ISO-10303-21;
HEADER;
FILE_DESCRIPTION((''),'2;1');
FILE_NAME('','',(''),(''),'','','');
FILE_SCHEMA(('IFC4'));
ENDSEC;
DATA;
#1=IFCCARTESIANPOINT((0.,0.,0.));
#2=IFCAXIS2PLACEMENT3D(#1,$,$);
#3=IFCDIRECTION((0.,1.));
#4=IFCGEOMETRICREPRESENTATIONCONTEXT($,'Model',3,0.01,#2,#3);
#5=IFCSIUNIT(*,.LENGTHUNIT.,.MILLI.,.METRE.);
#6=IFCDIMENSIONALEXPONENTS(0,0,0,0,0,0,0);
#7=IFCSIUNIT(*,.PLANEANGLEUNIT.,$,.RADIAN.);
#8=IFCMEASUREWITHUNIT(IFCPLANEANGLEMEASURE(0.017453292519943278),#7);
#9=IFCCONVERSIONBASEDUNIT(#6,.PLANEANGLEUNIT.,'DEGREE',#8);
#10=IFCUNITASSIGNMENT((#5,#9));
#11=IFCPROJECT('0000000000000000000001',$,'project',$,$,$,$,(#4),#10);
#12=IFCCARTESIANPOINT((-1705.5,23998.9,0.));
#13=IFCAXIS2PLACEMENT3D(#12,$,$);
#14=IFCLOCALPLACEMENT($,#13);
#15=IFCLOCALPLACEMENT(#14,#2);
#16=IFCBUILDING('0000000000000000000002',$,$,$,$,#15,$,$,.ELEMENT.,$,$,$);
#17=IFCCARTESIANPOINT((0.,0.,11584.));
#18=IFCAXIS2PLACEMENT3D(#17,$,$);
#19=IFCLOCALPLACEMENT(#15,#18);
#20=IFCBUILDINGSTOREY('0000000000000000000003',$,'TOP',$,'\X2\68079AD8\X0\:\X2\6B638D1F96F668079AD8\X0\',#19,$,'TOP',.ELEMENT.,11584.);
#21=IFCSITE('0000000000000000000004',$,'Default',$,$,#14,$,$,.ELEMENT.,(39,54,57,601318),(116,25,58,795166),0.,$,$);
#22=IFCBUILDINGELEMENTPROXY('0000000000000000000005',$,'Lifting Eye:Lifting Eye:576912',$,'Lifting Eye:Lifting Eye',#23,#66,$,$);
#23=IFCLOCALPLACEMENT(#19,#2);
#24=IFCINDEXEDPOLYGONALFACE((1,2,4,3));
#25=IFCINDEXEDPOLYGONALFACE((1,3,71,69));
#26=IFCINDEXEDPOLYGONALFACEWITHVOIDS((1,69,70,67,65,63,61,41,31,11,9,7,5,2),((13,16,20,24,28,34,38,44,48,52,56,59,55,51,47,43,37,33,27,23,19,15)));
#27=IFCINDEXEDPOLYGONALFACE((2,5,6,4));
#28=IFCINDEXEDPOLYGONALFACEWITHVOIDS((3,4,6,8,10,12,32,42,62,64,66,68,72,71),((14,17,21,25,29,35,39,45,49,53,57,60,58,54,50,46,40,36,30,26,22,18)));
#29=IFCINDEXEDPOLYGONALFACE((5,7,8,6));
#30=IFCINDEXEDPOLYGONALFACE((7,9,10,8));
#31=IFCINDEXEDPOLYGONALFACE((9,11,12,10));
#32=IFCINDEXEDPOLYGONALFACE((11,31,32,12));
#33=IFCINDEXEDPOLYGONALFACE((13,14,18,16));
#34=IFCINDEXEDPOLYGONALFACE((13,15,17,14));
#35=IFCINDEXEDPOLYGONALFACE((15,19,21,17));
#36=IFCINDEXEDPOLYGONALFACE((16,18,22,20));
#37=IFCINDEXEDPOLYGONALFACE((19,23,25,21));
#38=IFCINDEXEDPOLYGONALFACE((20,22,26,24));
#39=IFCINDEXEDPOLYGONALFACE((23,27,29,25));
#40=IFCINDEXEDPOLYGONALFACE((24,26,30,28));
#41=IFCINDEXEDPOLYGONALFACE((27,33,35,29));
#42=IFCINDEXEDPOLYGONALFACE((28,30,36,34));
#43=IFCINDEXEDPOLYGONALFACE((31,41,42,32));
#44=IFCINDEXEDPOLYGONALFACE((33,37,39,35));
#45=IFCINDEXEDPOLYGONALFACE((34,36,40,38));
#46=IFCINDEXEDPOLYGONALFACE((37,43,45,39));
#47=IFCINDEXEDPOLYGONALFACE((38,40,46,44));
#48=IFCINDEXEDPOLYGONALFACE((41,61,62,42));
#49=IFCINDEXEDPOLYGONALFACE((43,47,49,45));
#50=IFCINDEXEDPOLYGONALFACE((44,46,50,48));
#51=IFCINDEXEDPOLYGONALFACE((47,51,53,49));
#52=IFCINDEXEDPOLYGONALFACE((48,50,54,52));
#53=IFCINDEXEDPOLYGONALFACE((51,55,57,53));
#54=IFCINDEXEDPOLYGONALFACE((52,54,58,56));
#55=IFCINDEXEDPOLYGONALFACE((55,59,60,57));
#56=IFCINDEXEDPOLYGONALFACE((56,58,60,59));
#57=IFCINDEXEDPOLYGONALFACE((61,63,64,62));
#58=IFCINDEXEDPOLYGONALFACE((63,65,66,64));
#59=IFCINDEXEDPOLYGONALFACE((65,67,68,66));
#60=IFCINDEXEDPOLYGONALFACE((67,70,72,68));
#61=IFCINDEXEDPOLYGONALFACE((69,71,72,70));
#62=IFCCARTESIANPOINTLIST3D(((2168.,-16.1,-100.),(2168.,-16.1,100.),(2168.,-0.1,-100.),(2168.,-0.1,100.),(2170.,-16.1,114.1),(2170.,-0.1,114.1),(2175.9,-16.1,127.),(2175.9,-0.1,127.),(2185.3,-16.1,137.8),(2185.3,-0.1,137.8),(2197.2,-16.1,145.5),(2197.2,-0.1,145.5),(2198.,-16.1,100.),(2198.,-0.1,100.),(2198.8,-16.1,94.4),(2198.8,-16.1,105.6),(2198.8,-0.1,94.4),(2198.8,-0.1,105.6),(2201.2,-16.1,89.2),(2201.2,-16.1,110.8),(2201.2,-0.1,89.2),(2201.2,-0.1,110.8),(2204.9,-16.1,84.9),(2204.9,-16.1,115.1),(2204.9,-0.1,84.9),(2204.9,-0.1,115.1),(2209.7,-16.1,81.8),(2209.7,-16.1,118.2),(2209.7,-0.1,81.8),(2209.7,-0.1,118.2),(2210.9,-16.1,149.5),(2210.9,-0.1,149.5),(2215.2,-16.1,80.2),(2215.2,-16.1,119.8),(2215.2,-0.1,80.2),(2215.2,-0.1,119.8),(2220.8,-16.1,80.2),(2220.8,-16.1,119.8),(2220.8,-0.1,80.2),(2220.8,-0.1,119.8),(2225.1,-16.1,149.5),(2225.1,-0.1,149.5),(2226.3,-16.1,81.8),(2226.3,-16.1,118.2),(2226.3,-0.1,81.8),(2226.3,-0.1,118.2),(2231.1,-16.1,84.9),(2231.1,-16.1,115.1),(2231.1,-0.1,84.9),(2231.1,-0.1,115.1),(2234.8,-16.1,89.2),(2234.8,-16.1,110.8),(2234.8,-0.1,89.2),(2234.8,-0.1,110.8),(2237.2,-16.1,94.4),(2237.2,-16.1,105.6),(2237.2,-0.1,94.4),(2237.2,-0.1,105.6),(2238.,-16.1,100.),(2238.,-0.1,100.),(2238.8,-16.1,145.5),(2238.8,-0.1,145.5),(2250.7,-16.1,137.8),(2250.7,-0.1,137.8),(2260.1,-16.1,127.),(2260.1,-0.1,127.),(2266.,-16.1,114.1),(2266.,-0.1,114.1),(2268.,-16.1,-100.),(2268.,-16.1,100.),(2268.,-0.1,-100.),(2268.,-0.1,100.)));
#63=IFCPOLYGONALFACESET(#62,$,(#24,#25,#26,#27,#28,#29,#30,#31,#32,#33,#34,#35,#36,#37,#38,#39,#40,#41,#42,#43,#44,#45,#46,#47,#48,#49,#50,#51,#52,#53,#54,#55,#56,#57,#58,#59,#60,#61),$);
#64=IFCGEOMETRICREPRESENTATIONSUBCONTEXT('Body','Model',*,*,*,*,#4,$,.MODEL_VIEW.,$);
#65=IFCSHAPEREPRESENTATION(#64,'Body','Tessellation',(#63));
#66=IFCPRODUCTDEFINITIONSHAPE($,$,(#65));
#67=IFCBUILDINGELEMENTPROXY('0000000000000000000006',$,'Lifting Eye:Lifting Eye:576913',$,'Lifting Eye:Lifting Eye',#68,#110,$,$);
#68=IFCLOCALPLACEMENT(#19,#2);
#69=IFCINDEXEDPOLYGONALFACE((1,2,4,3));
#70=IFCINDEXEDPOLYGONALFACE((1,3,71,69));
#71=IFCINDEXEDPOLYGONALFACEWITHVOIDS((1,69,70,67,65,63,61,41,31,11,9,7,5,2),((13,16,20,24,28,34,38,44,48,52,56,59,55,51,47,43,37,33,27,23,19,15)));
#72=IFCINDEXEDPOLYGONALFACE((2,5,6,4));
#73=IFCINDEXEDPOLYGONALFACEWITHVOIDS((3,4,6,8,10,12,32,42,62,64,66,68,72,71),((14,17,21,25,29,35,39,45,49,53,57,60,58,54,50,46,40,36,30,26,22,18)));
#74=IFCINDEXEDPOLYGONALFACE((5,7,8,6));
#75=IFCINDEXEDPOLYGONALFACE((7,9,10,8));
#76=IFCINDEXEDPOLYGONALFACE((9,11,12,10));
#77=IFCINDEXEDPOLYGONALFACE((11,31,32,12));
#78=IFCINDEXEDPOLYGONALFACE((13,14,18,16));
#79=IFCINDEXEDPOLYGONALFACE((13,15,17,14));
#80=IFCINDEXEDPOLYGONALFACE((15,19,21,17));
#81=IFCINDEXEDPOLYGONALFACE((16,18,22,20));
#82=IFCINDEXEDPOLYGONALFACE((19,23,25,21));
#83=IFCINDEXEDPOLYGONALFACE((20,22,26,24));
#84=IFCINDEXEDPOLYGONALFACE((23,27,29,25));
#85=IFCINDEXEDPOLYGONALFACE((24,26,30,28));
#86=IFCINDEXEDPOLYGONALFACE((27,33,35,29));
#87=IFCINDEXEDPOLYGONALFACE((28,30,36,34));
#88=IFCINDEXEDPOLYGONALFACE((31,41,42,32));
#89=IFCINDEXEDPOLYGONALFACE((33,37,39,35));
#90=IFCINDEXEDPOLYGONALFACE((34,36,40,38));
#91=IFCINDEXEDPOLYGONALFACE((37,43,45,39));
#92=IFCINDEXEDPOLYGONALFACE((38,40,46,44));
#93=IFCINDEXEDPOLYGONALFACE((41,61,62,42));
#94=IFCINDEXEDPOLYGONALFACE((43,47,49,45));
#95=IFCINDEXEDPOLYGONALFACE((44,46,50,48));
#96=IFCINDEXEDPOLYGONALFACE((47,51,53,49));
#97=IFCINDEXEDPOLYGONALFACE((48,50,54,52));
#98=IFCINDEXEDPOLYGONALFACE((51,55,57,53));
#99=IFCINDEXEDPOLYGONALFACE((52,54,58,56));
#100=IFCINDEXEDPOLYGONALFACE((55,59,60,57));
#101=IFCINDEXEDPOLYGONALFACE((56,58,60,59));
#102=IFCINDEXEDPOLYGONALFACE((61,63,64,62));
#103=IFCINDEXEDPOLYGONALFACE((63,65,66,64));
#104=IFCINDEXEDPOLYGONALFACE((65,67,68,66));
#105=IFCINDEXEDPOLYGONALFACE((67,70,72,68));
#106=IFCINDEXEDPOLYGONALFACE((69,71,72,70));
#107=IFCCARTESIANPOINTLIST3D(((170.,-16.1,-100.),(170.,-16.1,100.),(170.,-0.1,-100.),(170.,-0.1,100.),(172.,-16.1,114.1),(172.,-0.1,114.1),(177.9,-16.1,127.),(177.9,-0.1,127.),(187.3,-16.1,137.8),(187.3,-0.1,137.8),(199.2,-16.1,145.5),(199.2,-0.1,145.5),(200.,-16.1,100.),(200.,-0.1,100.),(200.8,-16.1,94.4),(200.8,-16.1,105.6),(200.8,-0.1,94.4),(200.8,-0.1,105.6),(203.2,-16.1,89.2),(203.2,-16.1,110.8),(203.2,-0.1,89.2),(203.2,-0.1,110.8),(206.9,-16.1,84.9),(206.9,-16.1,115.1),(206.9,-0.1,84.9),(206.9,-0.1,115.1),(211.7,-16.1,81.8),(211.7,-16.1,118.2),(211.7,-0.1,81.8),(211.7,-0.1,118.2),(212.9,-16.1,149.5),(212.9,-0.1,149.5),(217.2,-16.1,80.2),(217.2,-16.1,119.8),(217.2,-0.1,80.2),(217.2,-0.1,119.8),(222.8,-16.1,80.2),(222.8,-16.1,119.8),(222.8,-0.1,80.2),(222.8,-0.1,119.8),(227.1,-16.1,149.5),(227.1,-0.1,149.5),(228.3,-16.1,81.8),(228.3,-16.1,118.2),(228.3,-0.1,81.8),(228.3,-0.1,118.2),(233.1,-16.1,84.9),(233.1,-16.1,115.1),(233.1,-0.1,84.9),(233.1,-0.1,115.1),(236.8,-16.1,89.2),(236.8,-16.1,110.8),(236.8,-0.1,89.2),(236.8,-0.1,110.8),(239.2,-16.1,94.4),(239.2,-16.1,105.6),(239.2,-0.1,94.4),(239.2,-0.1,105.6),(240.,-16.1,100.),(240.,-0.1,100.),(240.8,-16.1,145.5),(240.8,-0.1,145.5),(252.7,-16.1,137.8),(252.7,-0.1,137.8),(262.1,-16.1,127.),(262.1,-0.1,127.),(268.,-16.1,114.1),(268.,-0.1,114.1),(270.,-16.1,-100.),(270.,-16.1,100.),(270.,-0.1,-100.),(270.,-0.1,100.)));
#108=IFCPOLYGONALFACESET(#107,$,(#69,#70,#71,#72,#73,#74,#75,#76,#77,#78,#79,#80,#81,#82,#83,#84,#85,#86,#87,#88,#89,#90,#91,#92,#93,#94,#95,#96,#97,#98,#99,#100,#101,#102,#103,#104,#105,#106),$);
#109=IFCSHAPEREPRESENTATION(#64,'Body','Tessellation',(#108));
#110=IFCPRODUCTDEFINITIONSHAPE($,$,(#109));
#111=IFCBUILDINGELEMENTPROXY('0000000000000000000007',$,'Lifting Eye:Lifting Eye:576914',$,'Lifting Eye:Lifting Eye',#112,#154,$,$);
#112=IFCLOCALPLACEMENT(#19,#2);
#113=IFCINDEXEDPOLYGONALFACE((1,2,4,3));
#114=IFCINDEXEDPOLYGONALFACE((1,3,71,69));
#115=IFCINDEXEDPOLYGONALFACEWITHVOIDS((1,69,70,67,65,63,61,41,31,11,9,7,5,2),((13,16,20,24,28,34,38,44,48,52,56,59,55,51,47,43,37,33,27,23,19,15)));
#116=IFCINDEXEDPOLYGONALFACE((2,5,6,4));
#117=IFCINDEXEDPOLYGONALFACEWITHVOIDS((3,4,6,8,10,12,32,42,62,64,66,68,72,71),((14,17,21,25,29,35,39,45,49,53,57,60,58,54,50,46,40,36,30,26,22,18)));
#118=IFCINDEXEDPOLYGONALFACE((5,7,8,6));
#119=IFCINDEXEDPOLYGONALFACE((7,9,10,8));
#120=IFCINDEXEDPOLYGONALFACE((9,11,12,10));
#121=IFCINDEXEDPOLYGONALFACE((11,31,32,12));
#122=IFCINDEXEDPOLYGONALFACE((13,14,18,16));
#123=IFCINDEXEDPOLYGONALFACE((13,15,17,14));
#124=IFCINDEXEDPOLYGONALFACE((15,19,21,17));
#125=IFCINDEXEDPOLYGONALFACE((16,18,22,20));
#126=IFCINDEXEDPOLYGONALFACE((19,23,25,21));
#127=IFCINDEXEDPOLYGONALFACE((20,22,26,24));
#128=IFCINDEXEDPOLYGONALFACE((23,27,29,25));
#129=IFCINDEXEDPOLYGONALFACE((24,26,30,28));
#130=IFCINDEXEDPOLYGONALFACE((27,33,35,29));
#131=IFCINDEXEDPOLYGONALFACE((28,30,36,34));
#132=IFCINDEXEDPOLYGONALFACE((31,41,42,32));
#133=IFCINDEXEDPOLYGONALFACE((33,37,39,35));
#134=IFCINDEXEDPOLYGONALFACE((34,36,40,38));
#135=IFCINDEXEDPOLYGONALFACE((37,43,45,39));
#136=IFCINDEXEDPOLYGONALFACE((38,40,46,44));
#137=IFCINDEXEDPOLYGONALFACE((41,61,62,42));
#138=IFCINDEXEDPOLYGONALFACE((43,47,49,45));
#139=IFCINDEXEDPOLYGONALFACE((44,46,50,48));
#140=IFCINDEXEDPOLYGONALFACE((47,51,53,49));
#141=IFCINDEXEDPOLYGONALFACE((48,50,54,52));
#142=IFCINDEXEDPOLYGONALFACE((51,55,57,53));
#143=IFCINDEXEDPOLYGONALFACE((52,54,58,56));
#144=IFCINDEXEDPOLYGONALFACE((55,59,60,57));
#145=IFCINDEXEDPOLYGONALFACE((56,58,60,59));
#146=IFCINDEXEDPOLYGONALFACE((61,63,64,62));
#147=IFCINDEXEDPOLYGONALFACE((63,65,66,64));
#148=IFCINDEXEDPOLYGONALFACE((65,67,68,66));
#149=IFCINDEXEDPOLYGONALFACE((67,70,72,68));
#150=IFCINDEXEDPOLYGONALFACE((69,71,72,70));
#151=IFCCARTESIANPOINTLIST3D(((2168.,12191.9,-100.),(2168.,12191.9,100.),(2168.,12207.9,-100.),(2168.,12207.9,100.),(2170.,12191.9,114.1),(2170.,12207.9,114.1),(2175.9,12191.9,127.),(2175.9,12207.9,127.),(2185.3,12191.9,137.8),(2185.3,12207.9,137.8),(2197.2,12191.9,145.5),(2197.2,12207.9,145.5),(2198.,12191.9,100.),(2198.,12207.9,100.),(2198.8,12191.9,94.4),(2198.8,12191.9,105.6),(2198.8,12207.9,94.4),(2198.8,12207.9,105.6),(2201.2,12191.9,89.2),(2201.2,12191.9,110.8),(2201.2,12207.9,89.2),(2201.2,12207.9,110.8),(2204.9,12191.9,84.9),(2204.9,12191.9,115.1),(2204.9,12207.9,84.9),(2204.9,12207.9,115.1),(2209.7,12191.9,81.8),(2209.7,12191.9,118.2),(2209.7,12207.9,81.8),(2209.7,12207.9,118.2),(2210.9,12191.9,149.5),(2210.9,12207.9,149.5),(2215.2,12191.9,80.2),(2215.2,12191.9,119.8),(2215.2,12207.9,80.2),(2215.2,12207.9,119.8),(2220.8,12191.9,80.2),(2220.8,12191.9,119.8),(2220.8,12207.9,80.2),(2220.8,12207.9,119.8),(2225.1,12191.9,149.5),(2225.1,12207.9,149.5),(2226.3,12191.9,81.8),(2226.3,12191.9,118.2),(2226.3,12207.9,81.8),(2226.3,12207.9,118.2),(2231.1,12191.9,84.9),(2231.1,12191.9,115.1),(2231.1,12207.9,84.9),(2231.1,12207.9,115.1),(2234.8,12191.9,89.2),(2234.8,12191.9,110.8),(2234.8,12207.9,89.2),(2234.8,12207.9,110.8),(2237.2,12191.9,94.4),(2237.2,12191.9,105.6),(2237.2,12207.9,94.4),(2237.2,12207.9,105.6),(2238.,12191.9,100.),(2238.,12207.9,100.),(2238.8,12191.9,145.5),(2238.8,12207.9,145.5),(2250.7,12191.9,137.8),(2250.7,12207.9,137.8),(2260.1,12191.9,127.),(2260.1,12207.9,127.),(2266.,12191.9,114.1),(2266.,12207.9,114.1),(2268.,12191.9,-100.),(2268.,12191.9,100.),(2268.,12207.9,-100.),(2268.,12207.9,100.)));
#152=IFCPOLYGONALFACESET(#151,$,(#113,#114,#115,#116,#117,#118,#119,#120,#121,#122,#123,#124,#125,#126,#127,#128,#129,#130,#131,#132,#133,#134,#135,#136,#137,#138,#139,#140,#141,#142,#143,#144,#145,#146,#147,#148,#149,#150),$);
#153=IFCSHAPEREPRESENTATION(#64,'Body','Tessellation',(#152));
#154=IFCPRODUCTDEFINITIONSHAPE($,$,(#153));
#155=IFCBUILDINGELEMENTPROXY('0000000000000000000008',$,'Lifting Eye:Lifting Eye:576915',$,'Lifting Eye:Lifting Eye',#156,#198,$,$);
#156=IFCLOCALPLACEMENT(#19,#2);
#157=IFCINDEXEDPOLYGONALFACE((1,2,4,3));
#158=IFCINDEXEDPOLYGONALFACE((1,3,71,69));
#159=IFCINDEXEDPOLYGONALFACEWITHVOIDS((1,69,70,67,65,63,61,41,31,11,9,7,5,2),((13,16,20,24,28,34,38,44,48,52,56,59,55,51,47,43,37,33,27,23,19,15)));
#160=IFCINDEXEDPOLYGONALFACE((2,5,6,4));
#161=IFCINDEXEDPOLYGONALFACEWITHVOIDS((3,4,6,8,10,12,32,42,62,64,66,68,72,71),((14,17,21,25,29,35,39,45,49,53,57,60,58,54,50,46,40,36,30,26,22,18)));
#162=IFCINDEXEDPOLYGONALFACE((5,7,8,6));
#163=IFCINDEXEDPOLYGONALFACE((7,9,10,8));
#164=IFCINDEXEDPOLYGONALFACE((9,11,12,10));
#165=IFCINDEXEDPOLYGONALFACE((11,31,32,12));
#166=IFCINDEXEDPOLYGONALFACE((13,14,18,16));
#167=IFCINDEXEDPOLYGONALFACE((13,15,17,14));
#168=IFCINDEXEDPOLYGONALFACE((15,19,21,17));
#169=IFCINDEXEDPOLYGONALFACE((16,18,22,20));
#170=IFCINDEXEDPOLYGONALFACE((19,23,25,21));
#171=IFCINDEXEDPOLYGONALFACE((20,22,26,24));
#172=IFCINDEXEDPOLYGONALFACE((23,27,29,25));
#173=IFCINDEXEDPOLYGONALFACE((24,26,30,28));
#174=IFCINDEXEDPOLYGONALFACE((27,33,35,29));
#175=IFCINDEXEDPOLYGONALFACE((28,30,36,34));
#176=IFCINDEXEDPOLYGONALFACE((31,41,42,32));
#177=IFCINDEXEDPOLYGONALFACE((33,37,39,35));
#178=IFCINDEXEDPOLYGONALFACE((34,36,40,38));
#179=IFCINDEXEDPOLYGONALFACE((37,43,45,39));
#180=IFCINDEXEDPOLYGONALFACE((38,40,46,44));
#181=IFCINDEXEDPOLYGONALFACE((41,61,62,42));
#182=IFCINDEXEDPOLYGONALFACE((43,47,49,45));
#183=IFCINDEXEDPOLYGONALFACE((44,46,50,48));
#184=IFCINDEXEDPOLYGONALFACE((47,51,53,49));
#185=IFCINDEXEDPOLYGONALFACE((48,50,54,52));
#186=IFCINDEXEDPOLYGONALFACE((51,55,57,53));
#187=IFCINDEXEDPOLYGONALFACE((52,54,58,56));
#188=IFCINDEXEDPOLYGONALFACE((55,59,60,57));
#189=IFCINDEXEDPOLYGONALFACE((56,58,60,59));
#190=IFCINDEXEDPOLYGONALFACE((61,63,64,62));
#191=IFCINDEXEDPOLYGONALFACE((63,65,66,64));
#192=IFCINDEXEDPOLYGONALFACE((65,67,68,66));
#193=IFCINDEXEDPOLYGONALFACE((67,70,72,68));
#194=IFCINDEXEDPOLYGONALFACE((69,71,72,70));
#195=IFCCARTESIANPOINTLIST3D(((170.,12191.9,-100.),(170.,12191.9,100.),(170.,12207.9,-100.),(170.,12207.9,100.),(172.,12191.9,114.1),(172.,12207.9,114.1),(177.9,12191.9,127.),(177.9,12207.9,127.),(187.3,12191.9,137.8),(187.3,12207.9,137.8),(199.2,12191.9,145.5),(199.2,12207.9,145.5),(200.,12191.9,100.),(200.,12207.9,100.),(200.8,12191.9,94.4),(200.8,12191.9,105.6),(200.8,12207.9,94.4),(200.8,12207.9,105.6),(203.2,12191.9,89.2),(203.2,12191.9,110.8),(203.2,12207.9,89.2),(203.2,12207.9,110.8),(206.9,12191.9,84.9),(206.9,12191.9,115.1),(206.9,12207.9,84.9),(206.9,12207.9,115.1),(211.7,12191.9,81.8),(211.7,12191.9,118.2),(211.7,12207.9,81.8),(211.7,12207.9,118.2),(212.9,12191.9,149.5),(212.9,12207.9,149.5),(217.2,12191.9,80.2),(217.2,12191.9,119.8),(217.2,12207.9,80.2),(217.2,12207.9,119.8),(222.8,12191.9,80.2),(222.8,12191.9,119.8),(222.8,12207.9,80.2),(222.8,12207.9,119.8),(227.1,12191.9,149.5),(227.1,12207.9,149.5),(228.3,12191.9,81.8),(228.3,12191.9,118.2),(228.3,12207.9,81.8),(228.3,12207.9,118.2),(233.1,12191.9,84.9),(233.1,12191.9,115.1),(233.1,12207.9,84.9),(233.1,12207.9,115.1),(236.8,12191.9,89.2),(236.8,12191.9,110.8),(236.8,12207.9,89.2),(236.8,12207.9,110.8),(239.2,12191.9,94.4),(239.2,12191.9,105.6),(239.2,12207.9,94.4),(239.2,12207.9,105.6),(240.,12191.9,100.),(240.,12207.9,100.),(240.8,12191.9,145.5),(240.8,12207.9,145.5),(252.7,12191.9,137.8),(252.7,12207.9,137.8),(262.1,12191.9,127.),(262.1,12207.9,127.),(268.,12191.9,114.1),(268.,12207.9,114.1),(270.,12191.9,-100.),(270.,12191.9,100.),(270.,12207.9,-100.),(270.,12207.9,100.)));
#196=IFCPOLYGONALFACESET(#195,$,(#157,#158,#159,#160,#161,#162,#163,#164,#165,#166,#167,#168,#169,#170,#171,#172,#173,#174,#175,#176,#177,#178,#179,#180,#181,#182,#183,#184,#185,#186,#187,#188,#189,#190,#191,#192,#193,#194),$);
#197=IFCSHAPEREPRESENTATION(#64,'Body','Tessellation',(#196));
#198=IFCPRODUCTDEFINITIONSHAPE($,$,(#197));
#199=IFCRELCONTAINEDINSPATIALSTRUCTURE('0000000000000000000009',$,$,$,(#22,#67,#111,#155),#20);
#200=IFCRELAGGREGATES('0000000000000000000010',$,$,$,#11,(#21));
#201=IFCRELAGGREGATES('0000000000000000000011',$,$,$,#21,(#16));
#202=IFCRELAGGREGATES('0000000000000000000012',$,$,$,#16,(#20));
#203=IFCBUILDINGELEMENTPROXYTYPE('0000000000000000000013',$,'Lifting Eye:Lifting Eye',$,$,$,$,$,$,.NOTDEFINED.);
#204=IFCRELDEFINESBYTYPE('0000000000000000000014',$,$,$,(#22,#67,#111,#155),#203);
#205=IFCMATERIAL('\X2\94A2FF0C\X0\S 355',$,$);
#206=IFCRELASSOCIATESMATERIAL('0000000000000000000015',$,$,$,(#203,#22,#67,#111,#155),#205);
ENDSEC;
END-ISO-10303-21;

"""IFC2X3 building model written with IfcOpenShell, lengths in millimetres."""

from ifc_helpers import new_model, entity, si_unit, converted_unit, direction, frame, frame_2d, origin, place, context, subcontext, project, spatial, polyline, circle_curve, parameter, trimmed, segment, composite_curve, outline, extrude, source, transform, mapped, material, type_object, type_shapes, element, save


model = new_model("IFC2X3")

# Units and contexts
model_context = context("Model", 3, precision=0.01, world=origin(), true_north=direction((0.0, 1.0)))
body_context = subcontext(model_context, "Body", "Model", "MODEL_VIEW")
ifc_project = project(units=[si_unit("LENGTHUNIT", "METRE", prefix="MILLI"), converted_unit("PLANEANGLEUNIT", "DEGREE", entity("IfcPlaneAngleMeasure", 0.017453292519943278), si_unit("PLANEANGLEUNIT", "RADIAN"), dimensions=[0, 0, 0, 0, 0, 0, 0])], contexts=[model_context])

# Site, building, storey
site_placement = place(None, frame((-1705.5, 23998.9, 0.0)))
site = spatial("IfcSite", under=ifc_project, at=site_placement, Name="Default", CompositionType="ELEMENT", RefLatitude=(39, 54, 57, 601318), RefLongitude=(116, 25, 58, 795166), RefElevation=0.0)
building_placement = place(site_placement, origin())
building = spatial("IfcBuilding", under=site, at=building_placement, CompositionType="ELEMENT")
storey_placement = place(building_placement, frame((0.0, 0.0, 11584.0)))
storey = spatial("IfcBuildingStorey", under=building, at=storey_placement, Name="TOP", ObjectType="标高:正负零标高", LongName="TOP", CompositionType="ELEMENT", Elevation=11584.0)

# Building element proxies
ifc_material_1 = material(Name="钢，S 355")
building_element_proxy_type = type_object("IfcBuildingElementProxyType", Name="Lifting Eye:Lifting Eye", PredefinedType="NOTDEFINED", material=ifc_material_1)
shared_shape = source(origin(), body_context, "Body", "SweptSolid", [
    extrude(outline(composite_curve([segment(polyline([(-100.0, -50.0), (100.0, -50.0)]), True, "CONTINUOUS"), segment(polyline([(100.0, -50.0), (100.0, 50.0)]), True, "CONTINUOUS"), segment(polyline([(100.0, 50.0), (-100.0, 50.0)]), True, "CONTINUOUS"), segment(trimmed(circle_curve(frame_2d((-100.0, 0.0), x_axis=(0.0, -1.0)), 50.0), [parameter(180.0)], [parameter(0.0)], True, "PARAMETER"), True, "CONTINUOUS")], self_intersect=False), holes=[composite_curve([segment(trimmed(circle_curve(frame_2d((-100.0, 0.0), x_axis=(0.0, -1.0)), 20.0), [parameter(180.0)], [parameter(360.0)], True, "PARAMETER"), False, "CONTINUOUS"), segment(trimmed(circle_curve(frame_2d((-100.0, 0.0), x_axis=(0.0, -1.0)), 20.0), [parameter(0.0)], [parameter(180.0)], True, "PARAMETER"), False, "CONTINUOUS")], self_intersect=False)]), frame((0.0, 17.0, -17.0), z_axis=(0.0, 1.0, 0.0), x_axis=(0.0, 0.0, -1.0)), (0.0, 0.0, 1.0), 16.0),
])
type_shapes(building_element_proxy_type, [shared_shape])
for number, where, name in (
    (1, (2218.0, -33.1, 17.0), "Lifting Eye:Lifting Eye:576912"),
    (2, (220.0, -33.1, 17.0), "Lifting Eye:Lifting Eye:576913"),
    (3, (2218.0, 12174.9, 17.0), "Lifting Eye:Lifting Eye:576914"),
    (4, (220.0, 12174.9, 17.0), "Lifting Eye:Lifting Eye:576915"),
):
    element("IfcBuildingElementProxy", number, at=place(storey_placement, frame(where)), inside=storey, type_object=building_element_proxy_type, material=ifc_material_1, Name=name, ObjectType="Lifting Eye:Lifting Eye", context=body_context, shape_type="MappedRepresentation", body=[
        mapped(shared_shape, transform((0.0, 0.0, 0.0), scale=1.0)),
    ])

save(model, "model.ifc")
